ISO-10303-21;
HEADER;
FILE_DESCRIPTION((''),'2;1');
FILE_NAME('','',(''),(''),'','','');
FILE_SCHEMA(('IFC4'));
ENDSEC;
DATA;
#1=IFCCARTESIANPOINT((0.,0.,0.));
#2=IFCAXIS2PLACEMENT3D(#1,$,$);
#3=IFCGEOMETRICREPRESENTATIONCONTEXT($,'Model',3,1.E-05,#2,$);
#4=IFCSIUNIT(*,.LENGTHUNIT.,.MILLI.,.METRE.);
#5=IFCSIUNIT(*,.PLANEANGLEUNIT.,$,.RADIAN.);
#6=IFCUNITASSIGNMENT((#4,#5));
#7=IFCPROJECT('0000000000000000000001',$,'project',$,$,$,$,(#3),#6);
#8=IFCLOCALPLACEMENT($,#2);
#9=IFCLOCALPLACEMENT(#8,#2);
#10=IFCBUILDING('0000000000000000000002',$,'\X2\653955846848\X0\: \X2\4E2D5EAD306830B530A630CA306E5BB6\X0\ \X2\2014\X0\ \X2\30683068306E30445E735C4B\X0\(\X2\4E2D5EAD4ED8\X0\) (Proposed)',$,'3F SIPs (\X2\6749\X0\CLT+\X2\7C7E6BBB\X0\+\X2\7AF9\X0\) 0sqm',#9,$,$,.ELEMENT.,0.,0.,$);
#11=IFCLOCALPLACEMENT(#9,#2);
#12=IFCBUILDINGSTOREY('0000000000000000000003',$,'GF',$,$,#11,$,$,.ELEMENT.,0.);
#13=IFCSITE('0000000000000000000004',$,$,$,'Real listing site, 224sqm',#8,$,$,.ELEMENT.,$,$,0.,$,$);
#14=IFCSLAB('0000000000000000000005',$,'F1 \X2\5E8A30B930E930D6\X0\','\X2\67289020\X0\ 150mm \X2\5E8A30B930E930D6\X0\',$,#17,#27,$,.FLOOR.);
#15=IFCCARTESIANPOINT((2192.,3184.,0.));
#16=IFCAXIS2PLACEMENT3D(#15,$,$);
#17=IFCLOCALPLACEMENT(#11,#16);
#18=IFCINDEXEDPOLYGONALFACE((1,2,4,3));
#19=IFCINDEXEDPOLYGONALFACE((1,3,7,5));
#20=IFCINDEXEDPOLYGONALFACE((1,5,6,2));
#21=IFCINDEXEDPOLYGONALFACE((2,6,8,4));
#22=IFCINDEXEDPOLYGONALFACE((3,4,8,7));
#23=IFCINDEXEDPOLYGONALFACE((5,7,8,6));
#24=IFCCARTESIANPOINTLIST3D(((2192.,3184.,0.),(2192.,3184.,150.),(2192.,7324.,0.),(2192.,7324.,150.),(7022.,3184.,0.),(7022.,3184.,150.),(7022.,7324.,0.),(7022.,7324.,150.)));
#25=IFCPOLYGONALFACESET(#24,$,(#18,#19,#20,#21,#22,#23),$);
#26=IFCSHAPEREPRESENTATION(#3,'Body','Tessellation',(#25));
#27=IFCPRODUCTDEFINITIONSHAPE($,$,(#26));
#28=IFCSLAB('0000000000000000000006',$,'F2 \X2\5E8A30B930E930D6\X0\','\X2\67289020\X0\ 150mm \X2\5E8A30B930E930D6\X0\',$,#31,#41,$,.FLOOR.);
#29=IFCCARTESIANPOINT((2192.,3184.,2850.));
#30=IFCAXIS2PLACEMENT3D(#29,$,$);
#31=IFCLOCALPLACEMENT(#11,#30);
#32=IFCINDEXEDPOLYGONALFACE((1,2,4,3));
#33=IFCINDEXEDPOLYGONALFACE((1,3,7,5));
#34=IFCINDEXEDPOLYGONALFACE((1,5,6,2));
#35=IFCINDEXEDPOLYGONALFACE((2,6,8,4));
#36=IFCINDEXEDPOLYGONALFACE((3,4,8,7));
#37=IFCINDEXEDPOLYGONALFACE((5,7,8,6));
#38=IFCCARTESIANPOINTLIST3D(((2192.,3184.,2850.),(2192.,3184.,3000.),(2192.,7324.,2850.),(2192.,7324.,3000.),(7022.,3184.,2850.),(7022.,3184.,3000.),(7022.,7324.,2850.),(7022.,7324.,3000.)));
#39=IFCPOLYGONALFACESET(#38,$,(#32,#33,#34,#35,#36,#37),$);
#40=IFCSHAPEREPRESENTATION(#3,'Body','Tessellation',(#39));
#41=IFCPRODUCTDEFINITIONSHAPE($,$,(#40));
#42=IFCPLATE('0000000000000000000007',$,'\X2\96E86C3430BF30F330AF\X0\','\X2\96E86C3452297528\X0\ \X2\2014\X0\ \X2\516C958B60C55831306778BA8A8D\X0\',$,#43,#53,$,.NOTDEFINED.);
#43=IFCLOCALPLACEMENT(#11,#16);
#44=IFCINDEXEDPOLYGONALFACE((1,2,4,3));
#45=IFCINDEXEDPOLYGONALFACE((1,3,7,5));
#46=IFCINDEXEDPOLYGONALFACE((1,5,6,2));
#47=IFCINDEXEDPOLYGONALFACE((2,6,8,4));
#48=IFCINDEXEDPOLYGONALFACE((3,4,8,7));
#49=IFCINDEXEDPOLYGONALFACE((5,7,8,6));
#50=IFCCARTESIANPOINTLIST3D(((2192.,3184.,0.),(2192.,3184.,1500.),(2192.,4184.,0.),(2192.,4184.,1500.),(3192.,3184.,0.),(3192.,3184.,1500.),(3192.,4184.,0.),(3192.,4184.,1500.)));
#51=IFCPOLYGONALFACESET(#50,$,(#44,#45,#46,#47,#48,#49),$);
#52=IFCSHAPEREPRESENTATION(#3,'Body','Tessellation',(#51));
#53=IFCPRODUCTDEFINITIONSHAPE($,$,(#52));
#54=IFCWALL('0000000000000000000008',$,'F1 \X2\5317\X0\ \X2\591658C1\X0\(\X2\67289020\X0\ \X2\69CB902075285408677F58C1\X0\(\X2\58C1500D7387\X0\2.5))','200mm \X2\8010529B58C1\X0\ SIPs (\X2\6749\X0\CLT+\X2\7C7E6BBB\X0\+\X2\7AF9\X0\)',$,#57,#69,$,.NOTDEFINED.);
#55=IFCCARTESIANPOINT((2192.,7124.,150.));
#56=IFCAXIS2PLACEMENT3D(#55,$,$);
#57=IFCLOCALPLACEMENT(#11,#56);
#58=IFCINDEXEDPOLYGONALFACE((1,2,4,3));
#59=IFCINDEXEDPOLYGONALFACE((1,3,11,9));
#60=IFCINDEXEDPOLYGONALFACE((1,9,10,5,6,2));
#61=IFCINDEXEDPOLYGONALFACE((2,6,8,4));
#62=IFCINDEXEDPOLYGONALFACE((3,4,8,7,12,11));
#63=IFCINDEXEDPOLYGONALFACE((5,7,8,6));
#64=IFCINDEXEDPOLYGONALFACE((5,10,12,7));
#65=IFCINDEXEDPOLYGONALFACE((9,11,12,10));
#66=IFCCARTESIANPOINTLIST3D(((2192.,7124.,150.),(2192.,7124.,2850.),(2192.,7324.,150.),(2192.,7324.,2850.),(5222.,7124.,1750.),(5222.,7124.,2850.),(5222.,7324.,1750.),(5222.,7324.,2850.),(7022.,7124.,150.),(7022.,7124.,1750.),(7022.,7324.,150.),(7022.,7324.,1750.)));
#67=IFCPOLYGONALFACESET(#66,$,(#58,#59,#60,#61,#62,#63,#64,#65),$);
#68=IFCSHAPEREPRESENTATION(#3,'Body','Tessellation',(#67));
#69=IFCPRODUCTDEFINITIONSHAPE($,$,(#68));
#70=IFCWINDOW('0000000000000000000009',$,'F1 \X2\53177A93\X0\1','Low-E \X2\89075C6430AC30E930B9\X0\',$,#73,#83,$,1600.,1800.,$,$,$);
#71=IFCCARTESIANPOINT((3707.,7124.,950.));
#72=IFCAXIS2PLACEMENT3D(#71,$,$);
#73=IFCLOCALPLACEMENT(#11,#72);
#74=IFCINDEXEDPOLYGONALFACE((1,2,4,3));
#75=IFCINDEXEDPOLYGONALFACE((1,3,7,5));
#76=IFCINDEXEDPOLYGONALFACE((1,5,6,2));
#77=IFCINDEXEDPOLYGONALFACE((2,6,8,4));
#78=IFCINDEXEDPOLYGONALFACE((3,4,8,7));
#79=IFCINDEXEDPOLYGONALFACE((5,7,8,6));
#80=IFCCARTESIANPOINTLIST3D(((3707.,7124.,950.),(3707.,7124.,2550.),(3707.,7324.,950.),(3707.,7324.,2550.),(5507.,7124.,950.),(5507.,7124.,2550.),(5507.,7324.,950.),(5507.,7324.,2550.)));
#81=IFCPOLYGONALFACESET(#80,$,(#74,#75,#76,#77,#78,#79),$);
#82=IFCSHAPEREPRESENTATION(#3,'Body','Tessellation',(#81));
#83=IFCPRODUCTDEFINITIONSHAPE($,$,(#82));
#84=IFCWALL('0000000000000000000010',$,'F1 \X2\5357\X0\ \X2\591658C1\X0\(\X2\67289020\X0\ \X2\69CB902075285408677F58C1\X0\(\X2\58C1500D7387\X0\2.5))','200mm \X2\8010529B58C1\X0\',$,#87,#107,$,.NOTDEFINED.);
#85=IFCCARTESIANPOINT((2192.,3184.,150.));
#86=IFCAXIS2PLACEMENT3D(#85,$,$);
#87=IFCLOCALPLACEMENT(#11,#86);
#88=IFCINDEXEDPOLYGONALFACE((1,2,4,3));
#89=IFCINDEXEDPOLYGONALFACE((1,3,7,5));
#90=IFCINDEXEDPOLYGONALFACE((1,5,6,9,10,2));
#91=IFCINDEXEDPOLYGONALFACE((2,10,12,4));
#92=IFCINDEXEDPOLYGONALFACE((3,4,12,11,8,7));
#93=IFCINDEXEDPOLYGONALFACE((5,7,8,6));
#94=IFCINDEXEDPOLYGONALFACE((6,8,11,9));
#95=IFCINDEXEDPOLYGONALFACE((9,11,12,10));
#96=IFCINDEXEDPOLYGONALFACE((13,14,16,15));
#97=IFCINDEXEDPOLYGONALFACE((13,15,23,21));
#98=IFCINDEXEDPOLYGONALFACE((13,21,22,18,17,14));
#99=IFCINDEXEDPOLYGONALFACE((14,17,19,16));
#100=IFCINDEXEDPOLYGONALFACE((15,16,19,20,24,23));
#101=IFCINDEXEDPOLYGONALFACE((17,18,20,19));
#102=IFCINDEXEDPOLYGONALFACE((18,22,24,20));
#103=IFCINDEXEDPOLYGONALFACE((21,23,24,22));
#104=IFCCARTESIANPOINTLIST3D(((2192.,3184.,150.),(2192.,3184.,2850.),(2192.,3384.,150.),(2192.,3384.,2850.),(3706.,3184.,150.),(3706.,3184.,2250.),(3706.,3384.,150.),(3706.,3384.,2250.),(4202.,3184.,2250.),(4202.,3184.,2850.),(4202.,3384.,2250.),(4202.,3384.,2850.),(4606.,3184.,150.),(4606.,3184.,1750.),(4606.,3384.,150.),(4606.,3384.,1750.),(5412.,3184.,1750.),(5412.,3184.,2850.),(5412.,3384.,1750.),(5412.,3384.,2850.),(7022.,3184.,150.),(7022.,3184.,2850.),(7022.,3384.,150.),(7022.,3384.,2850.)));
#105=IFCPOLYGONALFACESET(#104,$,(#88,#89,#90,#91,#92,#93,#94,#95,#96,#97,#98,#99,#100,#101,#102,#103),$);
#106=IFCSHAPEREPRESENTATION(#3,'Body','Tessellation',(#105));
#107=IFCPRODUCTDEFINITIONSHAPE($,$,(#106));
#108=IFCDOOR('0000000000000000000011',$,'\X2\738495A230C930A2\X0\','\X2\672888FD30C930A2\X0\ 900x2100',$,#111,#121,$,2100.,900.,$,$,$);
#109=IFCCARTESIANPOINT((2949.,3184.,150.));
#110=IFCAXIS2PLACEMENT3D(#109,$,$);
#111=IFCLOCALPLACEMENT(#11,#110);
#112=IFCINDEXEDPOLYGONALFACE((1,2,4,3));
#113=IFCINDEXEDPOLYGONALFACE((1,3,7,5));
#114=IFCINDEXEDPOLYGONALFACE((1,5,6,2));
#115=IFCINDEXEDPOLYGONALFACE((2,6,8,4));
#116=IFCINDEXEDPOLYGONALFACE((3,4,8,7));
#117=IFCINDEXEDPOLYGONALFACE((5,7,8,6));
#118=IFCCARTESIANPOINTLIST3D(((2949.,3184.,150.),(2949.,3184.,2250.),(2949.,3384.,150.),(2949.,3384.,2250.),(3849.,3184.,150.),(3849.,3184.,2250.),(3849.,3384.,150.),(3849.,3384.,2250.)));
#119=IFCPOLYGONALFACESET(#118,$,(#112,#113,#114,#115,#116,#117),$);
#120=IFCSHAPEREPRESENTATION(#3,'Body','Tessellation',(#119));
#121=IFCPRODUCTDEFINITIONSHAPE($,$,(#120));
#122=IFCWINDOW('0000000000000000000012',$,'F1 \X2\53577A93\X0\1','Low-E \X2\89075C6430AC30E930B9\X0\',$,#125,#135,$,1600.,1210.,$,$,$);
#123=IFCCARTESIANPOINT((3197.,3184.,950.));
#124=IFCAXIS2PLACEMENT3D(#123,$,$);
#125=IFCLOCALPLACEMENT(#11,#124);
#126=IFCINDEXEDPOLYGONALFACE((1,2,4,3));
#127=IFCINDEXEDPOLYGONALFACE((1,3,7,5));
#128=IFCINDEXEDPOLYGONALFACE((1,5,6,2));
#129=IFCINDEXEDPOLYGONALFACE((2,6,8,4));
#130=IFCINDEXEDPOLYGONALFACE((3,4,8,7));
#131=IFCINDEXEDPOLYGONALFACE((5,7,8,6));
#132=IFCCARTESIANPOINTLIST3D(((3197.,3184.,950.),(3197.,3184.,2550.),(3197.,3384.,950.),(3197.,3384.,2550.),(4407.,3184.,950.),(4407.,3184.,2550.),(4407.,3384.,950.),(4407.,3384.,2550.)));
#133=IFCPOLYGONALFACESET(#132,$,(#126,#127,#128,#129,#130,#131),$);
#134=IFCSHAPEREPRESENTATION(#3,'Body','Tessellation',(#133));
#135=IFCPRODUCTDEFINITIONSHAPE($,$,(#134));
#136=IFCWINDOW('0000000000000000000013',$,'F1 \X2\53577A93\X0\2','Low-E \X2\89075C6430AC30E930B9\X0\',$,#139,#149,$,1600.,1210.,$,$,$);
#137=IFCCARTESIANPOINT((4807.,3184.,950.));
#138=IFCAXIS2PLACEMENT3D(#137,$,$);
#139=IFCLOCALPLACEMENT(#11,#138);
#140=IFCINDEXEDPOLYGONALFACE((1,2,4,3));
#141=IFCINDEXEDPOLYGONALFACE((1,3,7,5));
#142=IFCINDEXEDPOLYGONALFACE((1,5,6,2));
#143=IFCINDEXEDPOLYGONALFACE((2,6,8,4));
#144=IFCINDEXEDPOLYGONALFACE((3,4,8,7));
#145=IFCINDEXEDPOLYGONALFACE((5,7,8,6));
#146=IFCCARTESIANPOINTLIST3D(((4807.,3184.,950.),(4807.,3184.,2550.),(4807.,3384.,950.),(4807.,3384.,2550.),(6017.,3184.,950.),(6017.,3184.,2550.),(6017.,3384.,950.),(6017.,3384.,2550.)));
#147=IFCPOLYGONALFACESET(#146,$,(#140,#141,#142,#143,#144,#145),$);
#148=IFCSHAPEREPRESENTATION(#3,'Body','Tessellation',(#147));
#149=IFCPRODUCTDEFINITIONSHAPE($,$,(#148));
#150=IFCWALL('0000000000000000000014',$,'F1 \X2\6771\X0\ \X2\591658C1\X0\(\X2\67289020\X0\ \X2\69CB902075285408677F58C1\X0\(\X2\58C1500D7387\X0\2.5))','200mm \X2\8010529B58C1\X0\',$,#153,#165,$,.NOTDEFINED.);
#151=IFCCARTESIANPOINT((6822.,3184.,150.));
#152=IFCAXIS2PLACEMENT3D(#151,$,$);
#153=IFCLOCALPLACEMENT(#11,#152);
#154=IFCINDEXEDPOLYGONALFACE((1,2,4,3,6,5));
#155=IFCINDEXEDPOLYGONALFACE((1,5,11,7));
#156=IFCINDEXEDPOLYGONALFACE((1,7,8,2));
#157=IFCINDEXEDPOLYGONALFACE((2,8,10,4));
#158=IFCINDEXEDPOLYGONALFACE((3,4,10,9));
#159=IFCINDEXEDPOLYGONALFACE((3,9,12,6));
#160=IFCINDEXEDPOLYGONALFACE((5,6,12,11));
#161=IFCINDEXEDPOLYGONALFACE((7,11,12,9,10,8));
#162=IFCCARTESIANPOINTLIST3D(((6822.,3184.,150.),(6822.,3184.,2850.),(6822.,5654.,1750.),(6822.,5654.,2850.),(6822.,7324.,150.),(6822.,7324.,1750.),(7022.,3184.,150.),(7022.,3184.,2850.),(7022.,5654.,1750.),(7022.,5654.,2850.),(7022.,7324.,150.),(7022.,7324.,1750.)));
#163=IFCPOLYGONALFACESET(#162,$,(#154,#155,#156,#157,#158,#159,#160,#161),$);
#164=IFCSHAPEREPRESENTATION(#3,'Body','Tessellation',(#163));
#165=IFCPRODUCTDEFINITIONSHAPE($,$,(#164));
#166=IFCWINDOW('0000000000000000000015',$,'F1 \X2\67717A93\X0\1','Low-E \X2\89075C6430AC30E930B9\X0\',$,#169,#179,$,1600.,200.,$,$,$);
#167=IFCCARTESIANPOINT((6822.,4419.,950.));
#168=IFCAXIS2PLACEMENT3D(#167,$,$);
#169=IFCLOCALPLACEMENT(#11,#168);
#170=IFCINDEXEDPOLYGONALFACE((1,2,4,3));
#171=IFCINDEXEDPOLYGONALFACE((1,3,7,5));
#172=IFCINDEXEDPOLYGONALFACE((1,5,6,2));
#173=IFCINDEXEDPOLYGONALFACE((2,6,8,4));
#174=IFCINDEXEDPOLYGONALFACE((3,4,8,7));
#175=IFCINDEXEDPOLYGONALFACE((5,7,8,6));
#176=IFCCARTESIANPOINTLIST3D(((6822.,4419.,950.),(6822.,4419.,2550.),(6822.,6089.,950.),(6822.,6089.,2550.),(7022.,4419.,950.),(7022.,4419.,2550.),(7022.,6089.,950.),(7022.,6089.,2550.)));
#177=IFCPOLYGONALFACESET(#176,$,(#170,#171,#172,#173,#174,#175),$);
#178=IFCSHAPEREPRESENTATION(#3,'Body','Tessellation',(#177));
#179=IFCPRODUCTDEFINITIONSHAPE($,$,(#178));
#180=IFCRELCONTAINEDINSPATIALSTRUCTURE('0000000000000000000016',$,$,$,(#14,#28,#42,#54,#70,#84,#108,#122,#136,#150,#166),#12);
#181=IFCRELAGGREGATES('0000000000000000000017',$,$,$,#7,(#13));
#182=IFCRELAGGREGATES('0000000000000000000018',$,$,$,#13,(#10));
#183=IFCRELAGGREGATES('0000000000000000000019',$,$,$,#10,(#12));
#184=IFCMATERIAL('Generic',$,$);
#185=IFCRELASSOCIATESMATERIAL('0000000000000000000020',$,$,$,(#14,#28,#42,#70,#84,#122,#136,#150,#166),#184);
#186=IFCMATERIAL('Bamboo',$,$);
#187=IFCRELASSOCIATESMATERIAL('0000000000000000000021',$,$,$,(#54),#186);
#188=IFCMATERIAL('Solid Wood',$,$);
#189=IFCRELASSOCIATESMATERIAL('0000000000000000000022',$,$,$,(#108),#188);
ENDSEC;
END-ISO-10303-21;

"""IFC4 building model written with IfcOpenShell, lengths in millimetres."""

from ifc_helpers import new_model, si_unit, frame, frame_2d, origin, place, context, project, spatial, rectangle, extrude, material, element, fill, save


model = new_model("IFC4")

# Units and contexts
model_context = context("Model", 3, precision=1e-05, world=origin())
ifc_project = project(units=[si_unit("LENGTHUNIT", "METRE", prefix="MILLI"), si_unit("PLANEANGLEUNIT", "RADIAN")], contexts=[model_context])

# Site, building, storey
site_placement = place(None, origin())
site = spatial("IfcSite", under=ifc_project, at=site_placement, ObjectType="Real listing site, 224sqm", CompositionType="ELEMENT", RefElevation=0.0)
building_placement = place(site_placement, origin())
building = spatial("IfcBuilding", under=site, at=building_placement, Name="改善案: 中庭とサウナの家 — ととのい平屋(中庭付) (Proposed)", ObjectType="3F SIPs (杉CLT+籾殻+竹) 0sqm", CompositionType="ELEMENT", ElevationOfRefHeight=0.0, ElevationOfTerrain=0.0)
storey_placement = place(building_placement, origin())
storey = spatial("IfcBuildingStorey", under=building, at=storey_placement, Name="GF", CompositionType="ELEMENT", Elevation=0.0)

# Slabs
ifc_material_1 = material(Name="Generic")
slab_1_placement = place(storey_placement, frame((2192.0, 3184.0, 0.0)))
element("IfcSlab", 1, at=slab_1_placement, inside=storey, material=ifc_material_1, Name="F1 床スラブ", Description="木造 150mm 床スラブ", PredefinedType="FLOOR", context=model_context, shape_type="SweptSolid", body=[
    extrude(rectangle(XDim=4830.0, YDim=4140.0, at=frame_2d((2415.0, 2070.0))), frame((2192.0, 3184.0, 0.0)), (0.0, 0.0, 1.0), 150.0),
])
slab_2_placement = place(storey_placement, frame((2192.0, 3184.0, 2850.0)))
element("IfcSlab", 2, at=slab_2_placement, inside=storey, material=ifc_material_1, Name="F2 床スラブ", Description="木造 150mm 床スラブ", PredefinedType="FLOOR", context=model_context, shape_type="SweptSolid", body=[
    extrude(rectangle(XDim=4830.0, YDim=4140.0, at=frame_2d((2415.0, 2070.0))), frame((2192.0, 3184.0, 2850.0)), (0.0, 0.0, 1.0), 150.0),
])

# Plate
plate_placement = place(storey_placement, frame((2192.0, 3184.0, 0.0)))
element("IfcPlate", 3, at=plate_placement, inside=storey, material=ifc_material_1, Name="雨水タンク", Description="雨水利用 — 公開情報で確認", PredefinedType="NOTDEFINED", context=model_context, shape_type="SweptSolid", body=[
    extrude(rectangle(XDim=1000.0, YDim=1000.0, at=frame_2d((500.0, 500.0))), frame((2192.0, 3184.0, 0.0)), (0.0, 0.0, 1.0), 1500.0),
])

# Wall, opening, window
ifc_material_2 = material(Name="Bamboo")
wall_1_placement = place(storey_placement, frame((2192.0, 7124.0, 150.0)))
wall_1 = element("IfcWall", 4, at=wall_1_placement, inside=storey, material=ifc_material_2, Name="F1 北 外壁(木造 構造用合板壁(壁倍率2.5))", Description="200mm 耐力壁 SIPs (杉CLT+籾殻+竹)", PredefinedType="NOTDEFINED", context=model_context, shape_type="SweptSolid", body=[
    extrude(rectangle(XDim=4830.0, YDim=200.0, at=frame_2d((2415.0, 100.0))), frame((2192.0, 7124.0, 150.0)), (0.0, 0.0, 1.0), 2700.0),
])
opening_1_placement = place(storey_placement, frame((3707.0, 7124.0, 950.0)))
opening_1 = element("IfcOpeningElement", 5, at=opening_1_placement, cuts=wall_1, PredefinedType="NOTDEFINED", context=model_context, shape_type="SweptSolid", body=[
    extrude(rectangle(XDim=1800.0, YDim=200.0, at=frame_2d((900.0, 100.0))), frame((3707.0, 7124.0, 950.0)), (0.0, 0.0, 1.0), 1600.0),
])
window_1_placement = place(storey_placement, frame((3707.0, 7124.0, 950.0)))
window_1 = element("IfcWindow", 6, at=window_1_placement, inside=storey, material=ifc_material_1, Name="F1 北窓1", Description="Low-E 複層ガラス", OverallHeight=1600.0, OverallWidth=1800.0, context=model_context, shape_type="SweptSolid", body=[
    extrude(rectangle(XDim=1800.0, YDim=200.0, at=frame_2d((900.0, 100.0))), frame((3707.0, 7124.0, 950.0)), (0.0, 0.0, 1.0), 1600.0),
])
fill(opening_1, window_1)

# Wall, openings, door, windows
wall_2_placement = place(storey_placement, frame((2192.0, 3184.0, 150.0)))
wall_2 = element("IfcWall", 7, at=wall_2_placement, inside=storey, material=ifc_material_1, Name="F1 南 外壁(木造 構造用合板壁(壁倍率2.5))", Description="200mm 耐力壁", PredefinedType="NOTDEFINED", context=model_context, shape_type="SweptSolid", body=[
    extrude(rectangle(XDim=4830.0, YDim=200.0, at=frame_2d((2415.0, 100.0))), frame((2192.0, 3184.0, 150.0)), (0.0, 0.0, 1.0), 2700.0),
])
opening_2_placement = place(storey_placement, frame((2949.0, 3184.0, 150.0)))
opening_2 = element("IfcOpeningElement", 8, at=opening_2_placement, cuts=wall_2, PredefinedType="NOTDEFINED", context=model_context, shape_type="SweptSolid", body=[
    extrude(rectangle(XDim=900.0, YDim=200.0, at=frame_2d((450.0, 100.0))), frame((2949.0, 3184.0, 150.0)), (0.0, 0.0, 1.0), 2100.0),
])
opening_3_placement = place(storey_placement, frame((3197.0, 3184.0, 950.0)))
opening_3 = element("IfcOpeningElement", 9, at=opening_3_placement, cuts=wall_2, PredefinedType="NOTDEFINED", context=model_context, shape_type="SweptSolid", body=[
    extrude(rectangle(XDim=1210.0, YDim=200.0, at=frame_2d((605.0, 100.0))), frame((3197.0, 3184.0, 950.0)), (0.0, 0.0, 1.0), 1600.0),
])
opening_4_placement = place(storey_placement, frame((4807.0, 3184.0, 950.0)))
opening_4 = element("IfcOpeningElement", 10, at=opening_4_placement, cuts=wall_2, PredefinedType="NOTDEFINED", context=model_context, shape_type="SweptSolid", body=[
    extrude(rectangle(XDim=1210.0, YDim=200.0, at=frame_2d((605.0, 100.0))), frame((4807.0, 3184.0, 950.0)), (0.0, 0.0, 1.0), 1600.0),
])
ifc_material_3 = material(Name="Solid Wood")
door_placement = place(storey_placement, frame((2949.0, 3184.0, 150.0)))
door = element("IfcDoor", 11, at=door_placement, inside=storey, material=ifc_material_3, Name="玄関ドア", Description="木製ドア 900x2100", OverallHeight=2100.0, OverallWidth=900.0, context=model_context, shape_type="SweptSolid", body=[
    extrude(rectangle(XDim=900.0, YDim=200.0, at=frame_2d((450.0, 100.0))), frame((2949.0, 3184.0, 150.0)), (0.0, 0.0, 1.0), 2100.0),
])
fill(opening_2, door)
window_2_placement = place(storey_placement, frame((3197.0, 3184.0, 950.0)))
window_2 = element("IfcWindow", 12, at=window_2_placement, inside=storey, material=ifc_material_1, Name="F1 南窓1", Description="Low-E 複層ガラス", OverallHeight=1600.0, OverallWidth=1210.0, context=model_context, shape_type="SweptSolid", body=[
    extrude(rectangle(XDim=1210.0, YDim=200.0, at=frame_2d((605.0, 100.0))), frame((3197.0, 3184.0, 950.0)), (0.0, 0.0, 1.0), 1600.0),
])
fill(opening_3, window_2)
window_3_placement = place(storey_placement, frame((4807.0, 3184.0, 950.0)))
window_3 = element("IfcWindow", 13, at=window_3_placement, inside=storey, material=ifc_material_1, Name="F1 南窓2", Description="Low-E 複層ガラス", OverallHeight=1600.0, OverallWidth=1210.0, context=model_context, shape_type="SweptSolid", body=[
    extrude(rectangle(XDim=1210.0, YDim=200.0, at=frame_2d((605.0, 100.0))), frame((4807.0, 3184.0, 950.0)), (0.0, 0.0, 1.0), 1600.0),
])
fill(opening_4, window_3)

# Wall, opening, window
wall_3_placement = place(storey_placement, frame((6822.0, 3184.0, 150.0)))
wall_3 = element("IfcWall", 14, at=wall_3_placement, inside=storey, material=ifc_material_1, Name="F1 東 外壁(木造 構造用合板壁(壁倍率2.5))", Description="200mm 耐力壁", PredefinedType="NOTDEFINED", context=model_context, shape_type="SweptSolid", body=[
    extrude(rectangle(XDim=200.0, YDim=4140.0, at=frame_2d((100.0, 2070.0))), frame((6822.0, 3184.0, 150.0)), (0.0, 0.0, 1.0), 2700.0),
])
opening_5_placement = place(storey_placement, frame((6822.0, 4419.0, 950.0)))
opening_5 = element("IfcOpeningElement", 15, at=opening_5_placement, cuts=wall_3, PredefinedType="NOTDEFINED", context=model_context, shape_type="SweptSolid", body=[
    extrude(rectangle(XDim=200.0, YDim=1670.0, at=frame_2d((100.0, 835.0))), frame((6822.0, 4419.0, 950.0)), (0.0, 0.0, 1.0), 1600.0),
])
window_4_placement = place(storey_placement, frame((6822.0, 4419.0, 950.0)))
window_4 = element("IfcWindow", 16, at=window_4_placement, inside=storey, material=ifc_material_1, Name="F1 東窓1", Description="Low-E 複層ガラス", OverallHeight=1600.0, OverallWidth=200.0, context=model_context, shape_type="SweptSolid", body=[
    extrude(rectangle(XDim=200.0, YDim=1670.0, at=frame_2d((100.0, 835.0))), frame((6822.0, 4419.0, 950.0)), (0.0, 0.0, 1.0), 1600.0),
])
fill(opening_5, window_4)

save(model, "model.ifc")
